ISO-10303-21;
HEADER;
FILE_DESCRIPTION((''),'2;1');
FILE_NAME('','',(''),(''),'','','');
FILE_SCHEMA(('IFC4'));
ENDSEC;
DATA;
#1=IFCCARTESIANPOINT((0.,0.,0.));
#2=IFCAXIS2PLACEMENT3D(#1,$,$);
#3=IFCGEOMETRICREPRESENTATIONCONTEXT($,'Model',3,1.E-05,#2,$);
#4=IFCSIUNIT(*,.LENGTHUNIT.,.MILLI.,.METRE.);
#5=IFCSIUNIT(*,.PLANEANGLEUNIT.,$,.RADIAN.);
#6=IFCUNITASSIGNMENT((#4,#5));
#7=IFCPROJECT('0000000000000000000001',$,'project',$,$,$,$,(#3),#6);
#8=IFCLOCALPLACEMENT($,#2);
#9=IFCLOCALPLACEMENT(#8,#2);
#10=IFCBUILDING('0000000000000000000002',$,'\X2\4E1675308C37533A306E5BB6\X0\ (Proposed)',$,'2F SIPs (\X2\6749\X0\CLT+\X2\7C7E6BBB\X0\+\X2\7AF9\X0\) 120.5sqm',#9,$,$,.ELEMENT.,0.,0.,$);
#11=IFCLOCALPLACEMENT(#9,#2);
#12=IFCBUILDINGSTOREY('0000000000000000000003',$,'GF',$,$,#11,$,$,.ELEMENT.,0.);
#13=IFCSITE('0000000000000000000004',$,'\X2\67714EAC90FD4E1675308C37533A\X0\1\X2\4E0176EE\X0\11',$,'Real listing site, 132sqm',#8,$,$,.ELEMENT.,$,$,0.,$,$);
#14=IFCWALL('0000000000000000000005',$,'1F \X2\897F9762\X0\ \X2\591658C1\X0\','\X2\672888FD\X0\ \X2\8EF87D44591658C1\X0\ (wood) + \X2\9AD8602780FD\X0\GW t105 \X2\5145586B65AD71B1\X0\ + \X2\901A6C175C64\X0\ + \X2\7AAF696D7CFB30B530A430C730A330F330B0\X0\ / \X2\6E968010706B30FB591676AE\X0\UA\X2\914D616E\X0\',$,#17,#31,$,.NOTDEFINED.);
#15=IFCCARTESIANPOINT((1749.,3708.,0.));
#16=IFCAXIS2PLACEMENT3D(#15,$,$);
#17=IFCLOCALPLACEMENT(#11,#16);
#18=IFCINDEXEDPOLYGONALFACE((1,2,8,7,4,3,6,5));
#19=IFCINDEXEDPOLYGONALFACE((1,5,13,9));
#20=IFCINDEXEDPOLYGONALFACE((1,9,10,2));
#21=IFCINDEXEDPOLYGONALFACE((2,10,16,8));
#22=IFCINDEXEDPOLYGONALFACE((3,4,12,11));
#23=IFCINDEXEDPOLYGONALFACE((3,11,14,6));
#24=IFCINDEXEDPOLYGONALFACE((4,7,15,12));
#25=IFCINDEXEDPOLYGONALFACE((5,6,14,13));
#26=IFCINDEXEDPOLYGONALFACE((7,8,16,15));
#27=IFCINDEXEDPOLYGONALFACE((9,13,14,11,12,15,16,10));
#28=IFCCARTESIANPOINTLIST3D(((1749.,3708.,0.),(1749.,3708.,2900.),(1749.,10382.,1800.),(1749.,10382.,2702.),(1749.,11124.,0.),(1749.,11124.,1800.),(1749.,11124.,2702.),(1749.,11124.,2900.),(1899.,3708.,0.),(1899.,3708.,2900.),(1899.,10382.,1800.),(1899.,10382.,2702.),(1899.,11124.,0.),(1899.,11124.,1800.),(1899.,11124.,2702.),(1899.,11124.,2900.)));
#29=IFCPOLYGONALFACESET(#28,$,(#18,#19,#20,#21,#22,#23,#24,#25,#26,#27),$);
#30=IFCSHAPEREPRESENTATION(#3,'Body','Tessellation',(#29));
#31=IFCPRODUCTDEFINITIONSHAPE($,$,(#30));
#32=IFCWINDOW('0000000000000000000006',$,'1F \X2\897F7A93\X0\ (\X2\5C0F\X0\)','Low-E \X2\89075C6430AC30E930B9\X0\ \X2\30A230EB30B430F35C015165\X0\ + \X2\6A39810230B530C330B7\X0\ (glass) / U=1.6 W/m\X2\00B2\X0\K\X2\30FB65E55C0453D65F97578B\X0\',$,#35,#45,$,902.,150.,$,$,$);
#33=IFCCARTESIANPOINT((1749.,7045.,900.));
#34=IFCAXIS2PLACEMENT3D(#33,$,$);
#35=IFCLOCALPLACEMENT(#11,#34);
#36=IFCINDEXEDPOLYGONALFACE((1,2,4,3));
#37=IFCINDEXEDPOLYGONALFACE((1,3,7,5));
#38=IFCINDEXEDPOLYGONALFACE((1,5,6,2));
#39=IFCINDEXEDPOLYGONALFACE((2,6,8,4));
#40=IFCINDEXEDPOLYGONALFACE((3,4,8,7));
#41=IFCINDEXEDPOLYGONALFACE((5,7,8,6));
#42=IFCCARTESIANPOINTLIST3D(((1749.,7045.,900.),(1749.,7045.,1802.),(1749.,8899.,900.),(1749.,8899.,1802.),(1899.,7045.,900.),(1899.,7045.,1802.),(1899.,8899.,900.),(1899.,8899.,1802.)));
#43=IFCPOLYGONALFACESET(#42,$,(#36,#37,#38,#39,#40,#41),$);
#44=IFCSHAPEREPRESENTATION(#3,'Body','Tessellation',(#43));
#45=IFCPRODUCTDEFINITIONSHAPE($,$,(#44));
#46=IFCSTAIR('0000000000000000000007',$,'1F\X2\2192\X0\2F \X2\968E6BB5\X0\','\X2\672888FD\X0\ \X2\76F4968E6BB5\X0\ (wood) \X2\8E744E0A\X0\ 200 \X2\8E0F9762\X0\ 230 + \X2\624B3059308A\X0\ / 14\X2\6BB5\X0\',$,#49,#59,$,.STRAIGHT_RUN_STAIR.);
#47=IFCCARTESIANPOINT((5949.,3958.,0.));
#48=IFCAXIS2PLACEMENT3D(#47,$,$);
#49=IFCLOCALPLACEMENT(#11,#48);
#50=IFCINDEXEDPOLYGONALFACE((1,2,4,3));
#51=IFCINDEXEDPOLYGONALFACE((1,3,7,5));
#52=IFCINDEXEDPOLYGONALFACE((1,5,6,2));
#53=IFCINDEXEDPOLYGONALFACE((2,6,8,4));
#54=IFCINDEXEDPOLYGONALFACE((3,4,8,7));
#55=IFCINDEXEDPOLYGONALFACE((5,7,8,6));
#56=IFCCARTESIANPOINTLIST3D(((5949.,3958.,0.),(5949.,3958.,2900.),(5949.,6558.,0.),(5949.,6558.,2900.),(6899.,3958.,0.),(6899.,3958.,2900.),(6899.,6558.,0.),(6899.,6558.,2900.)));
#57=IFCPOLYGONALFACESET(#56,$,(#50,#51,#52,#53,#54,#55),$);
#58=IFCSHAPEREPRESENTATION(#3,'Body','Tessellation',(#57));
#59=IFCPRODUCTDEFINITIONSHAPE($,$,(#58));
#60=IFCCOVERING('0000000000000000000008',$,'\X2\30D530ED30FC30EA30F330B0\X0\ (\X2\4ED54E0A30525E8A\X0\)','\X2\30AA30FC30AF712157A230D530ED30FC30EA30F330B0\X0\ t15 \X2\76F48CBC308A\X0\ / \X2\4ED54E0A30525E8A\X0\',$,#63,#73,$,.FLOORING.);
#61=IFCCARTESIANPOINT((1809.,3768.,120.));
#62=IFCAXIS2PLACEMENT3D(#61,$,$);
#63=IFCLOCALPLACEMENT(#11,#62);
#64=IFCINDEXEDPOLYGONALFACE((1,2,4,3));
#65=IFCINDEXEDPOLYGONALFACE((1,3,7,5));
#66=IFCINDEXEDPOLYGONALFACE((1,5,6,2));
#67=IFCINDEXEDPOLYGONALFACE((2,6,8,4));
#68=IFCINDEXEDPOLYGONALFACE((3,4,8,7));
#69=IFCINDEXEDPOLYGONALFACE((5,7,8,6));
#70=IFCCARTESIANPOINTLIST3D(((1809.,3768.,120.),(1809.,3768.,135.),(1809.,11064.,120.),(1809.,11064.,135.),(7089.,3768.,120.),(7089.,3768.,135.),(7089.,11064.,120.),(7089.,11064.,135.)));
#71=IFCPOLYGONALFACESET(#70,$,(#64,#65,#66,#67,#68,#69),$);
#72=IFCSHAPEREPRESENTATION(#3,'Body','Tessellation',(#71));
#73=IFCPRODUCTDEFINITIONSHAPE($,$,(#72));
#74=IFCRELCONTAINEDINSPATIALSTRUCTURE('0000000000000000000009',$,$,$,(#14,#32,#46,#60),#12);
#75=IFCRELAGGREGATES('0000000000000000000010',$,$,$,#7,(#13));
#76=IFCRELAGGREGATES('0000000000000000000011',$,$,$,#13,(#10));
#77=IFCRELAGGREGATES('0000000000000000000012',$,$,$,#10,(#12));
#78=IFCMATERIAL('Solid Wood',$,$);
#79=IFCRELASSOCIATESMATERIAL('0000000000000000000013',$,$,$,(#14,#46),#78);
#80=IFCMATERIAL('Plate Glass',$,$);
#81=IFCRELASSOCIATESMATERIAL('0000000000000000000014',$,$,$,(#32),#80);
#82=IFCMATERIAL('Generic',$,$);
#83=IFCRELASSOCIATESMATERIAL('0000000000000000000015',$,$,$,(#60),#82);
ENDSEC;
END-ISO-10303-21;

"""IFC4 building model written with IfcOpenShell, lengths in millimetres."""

from ifc_helpers import new_model, si_unit, frame, frame_2d, origin, place, context, project, spatial, rectangle, extrude, material, element, fill, save


model = new_model("IFC4")

# Units and contexts
model_context = context("Model", 3, precision=1e-05, world=origin())
ifc_project = project(units=[si_unit("LENGTHUNIT", "METRE", prefix="MILLI"), si_unit("PLANEANGLEUNIT", "RADIAN")], contexts=[model_context])

# Site, building, storey
site_placement = place(None, origin())
site = spatial("IfcSite", under=ifc_project, at=site_placement, Name="東京都世田谷区1丁目11", ObjectType="Real listing site, 132sqm", CompositionType="ELEMENT", RefElevation=0.0)
building_placement = place(site_placement, origin())
building = spatial("IfcBuilding", under=site, at=building_placement, Name="世田谷区の家 (Proposed)", ObjectType="2F SIPs (杉CLT+籾殻+竹) 120.5sqm", CompositionType="ELEMENT", ElevationOfRefHeight=0.0, ElevationOfTerrain=0.0)
storey_placement = place(building_placement, origin())
storey = spatial("IfcBuildingStorey", under=building, at=storey_placement, Name="GF", CompositionType="ELEMENT", Elevation=0.0)

# Shared definitions
ifc_material_1 = material(Name="Solid Wood")
ifc_material_2 = material(Name="Generic")

# Shared definitions
ifc_material_3 = material(Name="Plate Glass")

# Wall, opening, window
wall_1_placement = place(storey_placement, frame((1749.0, 3708.0, 0.0)))
wall_1 = element("IfcWall", 1, at=wall_1_placement, inside=storey, material=ifc_material_1, Name="1F 西面 外壁", Description="木製 軸組外壁 (wood) + 高性能GW t105 充填断熱 + 通気層 + 窯業系サイディング / 準耐火・外皮UA配慮", PredefinedType="NOTDEFINED", context=model_context, shape_type="SweptSolid", body=[
    extrude(rectangle(XDim=150.0, YDim=7416.0, at=frame_2d((75.0, 3708.0))), frame((1749.0, 3708.0, 0.0)), (0.0, 0.0, 1.0), 2900.0),
])
opening_1_placement = place(storey_placement, frame((1749.0, 7045.0, 900.0)))
opening_1 = element("IfcOpeningElement", 2, at=opening_1_placement, cuts=wall_1, PredefinedType="NOTDEFINED", context=model_context, shape_type="SweptSolid", body=[
    extrude(rectangle(XDim=150.0, YDim=1854.0, at=frame_2d((75.0, 927.0))), frame((1749.0, 7045.0, 900.0)), (0.0, 0.0, 1.0), 902.0),
])
window_1_placement = place(storey_placement, frame((1749.0, 7045.0, 900.0)))
window_1 = element("IfcWindow", 3, at=window_1_placement, inside=storey, material=ifc_material_3, Name="1F 西窓 (小)", Description="Low-E 複層ガラス アルゴン封入 + 樹脂サッシ (glass) / U=1.6 W/m²K・日射取得型", OverallHeight=902.0, OverallWidth=150.0, context=model_context, shape_type="SweptSolid", body=[
    extrude(rectangle(XDim=150.0, YDim=1854.0, at=frame_2d((75.0, 927.0))), frame((1749.0, 7045.0, 900.0)), (0.0, 0.0, 1.0), 902.0),
])
fill(opening_1, window_1)

# Stair
stair_placement = place(storey_placement, frame((5949.0, 3958.0, 0.0)))
element("IfcStair", 4, at=stair_placement, inside=storey, material=ifc_material_1, Name="1F→2F 階段", Description="木製 直階段 (wood) 蹴上 200 踏面 230 + 手すり / 14段", PredefinedType="STRAIGHT_RUN_STAIR", context=model_context, shape_type="SweptSolid", body=[
    extrude(rectangle(XDim=950.0, YDim=2600.0, at=frame_2d((475.0, 1300.0))), frame((5949.0, 3958.0, 0.0)), (0.0, 0.0, 1.0), 2900.0),
])

# Covering
covering_placement = place(storey_placement, frame((1809.0, 3768.0, 120.0)))
element("IfcCovering", 5, at=covering_placement, inside=storey, material=ifc_material_2, Name="フローリング (仕上げ床)", Description="オーク無垢フローリング t15 直貼り / 仕上げ床", PredefinedType="FLOORING", context=model_context, shape_type="SweptSolid", body=[
    extrude(rectangle(XDim=5280.0, YDim=7296.0, at=frame_2d((2640.0, 3648.0))), frame((1809.0, 3768.0, 120.0)), (0.0, 0.0, 1.0), 15.0),
])

save(model, "model.ifc")
